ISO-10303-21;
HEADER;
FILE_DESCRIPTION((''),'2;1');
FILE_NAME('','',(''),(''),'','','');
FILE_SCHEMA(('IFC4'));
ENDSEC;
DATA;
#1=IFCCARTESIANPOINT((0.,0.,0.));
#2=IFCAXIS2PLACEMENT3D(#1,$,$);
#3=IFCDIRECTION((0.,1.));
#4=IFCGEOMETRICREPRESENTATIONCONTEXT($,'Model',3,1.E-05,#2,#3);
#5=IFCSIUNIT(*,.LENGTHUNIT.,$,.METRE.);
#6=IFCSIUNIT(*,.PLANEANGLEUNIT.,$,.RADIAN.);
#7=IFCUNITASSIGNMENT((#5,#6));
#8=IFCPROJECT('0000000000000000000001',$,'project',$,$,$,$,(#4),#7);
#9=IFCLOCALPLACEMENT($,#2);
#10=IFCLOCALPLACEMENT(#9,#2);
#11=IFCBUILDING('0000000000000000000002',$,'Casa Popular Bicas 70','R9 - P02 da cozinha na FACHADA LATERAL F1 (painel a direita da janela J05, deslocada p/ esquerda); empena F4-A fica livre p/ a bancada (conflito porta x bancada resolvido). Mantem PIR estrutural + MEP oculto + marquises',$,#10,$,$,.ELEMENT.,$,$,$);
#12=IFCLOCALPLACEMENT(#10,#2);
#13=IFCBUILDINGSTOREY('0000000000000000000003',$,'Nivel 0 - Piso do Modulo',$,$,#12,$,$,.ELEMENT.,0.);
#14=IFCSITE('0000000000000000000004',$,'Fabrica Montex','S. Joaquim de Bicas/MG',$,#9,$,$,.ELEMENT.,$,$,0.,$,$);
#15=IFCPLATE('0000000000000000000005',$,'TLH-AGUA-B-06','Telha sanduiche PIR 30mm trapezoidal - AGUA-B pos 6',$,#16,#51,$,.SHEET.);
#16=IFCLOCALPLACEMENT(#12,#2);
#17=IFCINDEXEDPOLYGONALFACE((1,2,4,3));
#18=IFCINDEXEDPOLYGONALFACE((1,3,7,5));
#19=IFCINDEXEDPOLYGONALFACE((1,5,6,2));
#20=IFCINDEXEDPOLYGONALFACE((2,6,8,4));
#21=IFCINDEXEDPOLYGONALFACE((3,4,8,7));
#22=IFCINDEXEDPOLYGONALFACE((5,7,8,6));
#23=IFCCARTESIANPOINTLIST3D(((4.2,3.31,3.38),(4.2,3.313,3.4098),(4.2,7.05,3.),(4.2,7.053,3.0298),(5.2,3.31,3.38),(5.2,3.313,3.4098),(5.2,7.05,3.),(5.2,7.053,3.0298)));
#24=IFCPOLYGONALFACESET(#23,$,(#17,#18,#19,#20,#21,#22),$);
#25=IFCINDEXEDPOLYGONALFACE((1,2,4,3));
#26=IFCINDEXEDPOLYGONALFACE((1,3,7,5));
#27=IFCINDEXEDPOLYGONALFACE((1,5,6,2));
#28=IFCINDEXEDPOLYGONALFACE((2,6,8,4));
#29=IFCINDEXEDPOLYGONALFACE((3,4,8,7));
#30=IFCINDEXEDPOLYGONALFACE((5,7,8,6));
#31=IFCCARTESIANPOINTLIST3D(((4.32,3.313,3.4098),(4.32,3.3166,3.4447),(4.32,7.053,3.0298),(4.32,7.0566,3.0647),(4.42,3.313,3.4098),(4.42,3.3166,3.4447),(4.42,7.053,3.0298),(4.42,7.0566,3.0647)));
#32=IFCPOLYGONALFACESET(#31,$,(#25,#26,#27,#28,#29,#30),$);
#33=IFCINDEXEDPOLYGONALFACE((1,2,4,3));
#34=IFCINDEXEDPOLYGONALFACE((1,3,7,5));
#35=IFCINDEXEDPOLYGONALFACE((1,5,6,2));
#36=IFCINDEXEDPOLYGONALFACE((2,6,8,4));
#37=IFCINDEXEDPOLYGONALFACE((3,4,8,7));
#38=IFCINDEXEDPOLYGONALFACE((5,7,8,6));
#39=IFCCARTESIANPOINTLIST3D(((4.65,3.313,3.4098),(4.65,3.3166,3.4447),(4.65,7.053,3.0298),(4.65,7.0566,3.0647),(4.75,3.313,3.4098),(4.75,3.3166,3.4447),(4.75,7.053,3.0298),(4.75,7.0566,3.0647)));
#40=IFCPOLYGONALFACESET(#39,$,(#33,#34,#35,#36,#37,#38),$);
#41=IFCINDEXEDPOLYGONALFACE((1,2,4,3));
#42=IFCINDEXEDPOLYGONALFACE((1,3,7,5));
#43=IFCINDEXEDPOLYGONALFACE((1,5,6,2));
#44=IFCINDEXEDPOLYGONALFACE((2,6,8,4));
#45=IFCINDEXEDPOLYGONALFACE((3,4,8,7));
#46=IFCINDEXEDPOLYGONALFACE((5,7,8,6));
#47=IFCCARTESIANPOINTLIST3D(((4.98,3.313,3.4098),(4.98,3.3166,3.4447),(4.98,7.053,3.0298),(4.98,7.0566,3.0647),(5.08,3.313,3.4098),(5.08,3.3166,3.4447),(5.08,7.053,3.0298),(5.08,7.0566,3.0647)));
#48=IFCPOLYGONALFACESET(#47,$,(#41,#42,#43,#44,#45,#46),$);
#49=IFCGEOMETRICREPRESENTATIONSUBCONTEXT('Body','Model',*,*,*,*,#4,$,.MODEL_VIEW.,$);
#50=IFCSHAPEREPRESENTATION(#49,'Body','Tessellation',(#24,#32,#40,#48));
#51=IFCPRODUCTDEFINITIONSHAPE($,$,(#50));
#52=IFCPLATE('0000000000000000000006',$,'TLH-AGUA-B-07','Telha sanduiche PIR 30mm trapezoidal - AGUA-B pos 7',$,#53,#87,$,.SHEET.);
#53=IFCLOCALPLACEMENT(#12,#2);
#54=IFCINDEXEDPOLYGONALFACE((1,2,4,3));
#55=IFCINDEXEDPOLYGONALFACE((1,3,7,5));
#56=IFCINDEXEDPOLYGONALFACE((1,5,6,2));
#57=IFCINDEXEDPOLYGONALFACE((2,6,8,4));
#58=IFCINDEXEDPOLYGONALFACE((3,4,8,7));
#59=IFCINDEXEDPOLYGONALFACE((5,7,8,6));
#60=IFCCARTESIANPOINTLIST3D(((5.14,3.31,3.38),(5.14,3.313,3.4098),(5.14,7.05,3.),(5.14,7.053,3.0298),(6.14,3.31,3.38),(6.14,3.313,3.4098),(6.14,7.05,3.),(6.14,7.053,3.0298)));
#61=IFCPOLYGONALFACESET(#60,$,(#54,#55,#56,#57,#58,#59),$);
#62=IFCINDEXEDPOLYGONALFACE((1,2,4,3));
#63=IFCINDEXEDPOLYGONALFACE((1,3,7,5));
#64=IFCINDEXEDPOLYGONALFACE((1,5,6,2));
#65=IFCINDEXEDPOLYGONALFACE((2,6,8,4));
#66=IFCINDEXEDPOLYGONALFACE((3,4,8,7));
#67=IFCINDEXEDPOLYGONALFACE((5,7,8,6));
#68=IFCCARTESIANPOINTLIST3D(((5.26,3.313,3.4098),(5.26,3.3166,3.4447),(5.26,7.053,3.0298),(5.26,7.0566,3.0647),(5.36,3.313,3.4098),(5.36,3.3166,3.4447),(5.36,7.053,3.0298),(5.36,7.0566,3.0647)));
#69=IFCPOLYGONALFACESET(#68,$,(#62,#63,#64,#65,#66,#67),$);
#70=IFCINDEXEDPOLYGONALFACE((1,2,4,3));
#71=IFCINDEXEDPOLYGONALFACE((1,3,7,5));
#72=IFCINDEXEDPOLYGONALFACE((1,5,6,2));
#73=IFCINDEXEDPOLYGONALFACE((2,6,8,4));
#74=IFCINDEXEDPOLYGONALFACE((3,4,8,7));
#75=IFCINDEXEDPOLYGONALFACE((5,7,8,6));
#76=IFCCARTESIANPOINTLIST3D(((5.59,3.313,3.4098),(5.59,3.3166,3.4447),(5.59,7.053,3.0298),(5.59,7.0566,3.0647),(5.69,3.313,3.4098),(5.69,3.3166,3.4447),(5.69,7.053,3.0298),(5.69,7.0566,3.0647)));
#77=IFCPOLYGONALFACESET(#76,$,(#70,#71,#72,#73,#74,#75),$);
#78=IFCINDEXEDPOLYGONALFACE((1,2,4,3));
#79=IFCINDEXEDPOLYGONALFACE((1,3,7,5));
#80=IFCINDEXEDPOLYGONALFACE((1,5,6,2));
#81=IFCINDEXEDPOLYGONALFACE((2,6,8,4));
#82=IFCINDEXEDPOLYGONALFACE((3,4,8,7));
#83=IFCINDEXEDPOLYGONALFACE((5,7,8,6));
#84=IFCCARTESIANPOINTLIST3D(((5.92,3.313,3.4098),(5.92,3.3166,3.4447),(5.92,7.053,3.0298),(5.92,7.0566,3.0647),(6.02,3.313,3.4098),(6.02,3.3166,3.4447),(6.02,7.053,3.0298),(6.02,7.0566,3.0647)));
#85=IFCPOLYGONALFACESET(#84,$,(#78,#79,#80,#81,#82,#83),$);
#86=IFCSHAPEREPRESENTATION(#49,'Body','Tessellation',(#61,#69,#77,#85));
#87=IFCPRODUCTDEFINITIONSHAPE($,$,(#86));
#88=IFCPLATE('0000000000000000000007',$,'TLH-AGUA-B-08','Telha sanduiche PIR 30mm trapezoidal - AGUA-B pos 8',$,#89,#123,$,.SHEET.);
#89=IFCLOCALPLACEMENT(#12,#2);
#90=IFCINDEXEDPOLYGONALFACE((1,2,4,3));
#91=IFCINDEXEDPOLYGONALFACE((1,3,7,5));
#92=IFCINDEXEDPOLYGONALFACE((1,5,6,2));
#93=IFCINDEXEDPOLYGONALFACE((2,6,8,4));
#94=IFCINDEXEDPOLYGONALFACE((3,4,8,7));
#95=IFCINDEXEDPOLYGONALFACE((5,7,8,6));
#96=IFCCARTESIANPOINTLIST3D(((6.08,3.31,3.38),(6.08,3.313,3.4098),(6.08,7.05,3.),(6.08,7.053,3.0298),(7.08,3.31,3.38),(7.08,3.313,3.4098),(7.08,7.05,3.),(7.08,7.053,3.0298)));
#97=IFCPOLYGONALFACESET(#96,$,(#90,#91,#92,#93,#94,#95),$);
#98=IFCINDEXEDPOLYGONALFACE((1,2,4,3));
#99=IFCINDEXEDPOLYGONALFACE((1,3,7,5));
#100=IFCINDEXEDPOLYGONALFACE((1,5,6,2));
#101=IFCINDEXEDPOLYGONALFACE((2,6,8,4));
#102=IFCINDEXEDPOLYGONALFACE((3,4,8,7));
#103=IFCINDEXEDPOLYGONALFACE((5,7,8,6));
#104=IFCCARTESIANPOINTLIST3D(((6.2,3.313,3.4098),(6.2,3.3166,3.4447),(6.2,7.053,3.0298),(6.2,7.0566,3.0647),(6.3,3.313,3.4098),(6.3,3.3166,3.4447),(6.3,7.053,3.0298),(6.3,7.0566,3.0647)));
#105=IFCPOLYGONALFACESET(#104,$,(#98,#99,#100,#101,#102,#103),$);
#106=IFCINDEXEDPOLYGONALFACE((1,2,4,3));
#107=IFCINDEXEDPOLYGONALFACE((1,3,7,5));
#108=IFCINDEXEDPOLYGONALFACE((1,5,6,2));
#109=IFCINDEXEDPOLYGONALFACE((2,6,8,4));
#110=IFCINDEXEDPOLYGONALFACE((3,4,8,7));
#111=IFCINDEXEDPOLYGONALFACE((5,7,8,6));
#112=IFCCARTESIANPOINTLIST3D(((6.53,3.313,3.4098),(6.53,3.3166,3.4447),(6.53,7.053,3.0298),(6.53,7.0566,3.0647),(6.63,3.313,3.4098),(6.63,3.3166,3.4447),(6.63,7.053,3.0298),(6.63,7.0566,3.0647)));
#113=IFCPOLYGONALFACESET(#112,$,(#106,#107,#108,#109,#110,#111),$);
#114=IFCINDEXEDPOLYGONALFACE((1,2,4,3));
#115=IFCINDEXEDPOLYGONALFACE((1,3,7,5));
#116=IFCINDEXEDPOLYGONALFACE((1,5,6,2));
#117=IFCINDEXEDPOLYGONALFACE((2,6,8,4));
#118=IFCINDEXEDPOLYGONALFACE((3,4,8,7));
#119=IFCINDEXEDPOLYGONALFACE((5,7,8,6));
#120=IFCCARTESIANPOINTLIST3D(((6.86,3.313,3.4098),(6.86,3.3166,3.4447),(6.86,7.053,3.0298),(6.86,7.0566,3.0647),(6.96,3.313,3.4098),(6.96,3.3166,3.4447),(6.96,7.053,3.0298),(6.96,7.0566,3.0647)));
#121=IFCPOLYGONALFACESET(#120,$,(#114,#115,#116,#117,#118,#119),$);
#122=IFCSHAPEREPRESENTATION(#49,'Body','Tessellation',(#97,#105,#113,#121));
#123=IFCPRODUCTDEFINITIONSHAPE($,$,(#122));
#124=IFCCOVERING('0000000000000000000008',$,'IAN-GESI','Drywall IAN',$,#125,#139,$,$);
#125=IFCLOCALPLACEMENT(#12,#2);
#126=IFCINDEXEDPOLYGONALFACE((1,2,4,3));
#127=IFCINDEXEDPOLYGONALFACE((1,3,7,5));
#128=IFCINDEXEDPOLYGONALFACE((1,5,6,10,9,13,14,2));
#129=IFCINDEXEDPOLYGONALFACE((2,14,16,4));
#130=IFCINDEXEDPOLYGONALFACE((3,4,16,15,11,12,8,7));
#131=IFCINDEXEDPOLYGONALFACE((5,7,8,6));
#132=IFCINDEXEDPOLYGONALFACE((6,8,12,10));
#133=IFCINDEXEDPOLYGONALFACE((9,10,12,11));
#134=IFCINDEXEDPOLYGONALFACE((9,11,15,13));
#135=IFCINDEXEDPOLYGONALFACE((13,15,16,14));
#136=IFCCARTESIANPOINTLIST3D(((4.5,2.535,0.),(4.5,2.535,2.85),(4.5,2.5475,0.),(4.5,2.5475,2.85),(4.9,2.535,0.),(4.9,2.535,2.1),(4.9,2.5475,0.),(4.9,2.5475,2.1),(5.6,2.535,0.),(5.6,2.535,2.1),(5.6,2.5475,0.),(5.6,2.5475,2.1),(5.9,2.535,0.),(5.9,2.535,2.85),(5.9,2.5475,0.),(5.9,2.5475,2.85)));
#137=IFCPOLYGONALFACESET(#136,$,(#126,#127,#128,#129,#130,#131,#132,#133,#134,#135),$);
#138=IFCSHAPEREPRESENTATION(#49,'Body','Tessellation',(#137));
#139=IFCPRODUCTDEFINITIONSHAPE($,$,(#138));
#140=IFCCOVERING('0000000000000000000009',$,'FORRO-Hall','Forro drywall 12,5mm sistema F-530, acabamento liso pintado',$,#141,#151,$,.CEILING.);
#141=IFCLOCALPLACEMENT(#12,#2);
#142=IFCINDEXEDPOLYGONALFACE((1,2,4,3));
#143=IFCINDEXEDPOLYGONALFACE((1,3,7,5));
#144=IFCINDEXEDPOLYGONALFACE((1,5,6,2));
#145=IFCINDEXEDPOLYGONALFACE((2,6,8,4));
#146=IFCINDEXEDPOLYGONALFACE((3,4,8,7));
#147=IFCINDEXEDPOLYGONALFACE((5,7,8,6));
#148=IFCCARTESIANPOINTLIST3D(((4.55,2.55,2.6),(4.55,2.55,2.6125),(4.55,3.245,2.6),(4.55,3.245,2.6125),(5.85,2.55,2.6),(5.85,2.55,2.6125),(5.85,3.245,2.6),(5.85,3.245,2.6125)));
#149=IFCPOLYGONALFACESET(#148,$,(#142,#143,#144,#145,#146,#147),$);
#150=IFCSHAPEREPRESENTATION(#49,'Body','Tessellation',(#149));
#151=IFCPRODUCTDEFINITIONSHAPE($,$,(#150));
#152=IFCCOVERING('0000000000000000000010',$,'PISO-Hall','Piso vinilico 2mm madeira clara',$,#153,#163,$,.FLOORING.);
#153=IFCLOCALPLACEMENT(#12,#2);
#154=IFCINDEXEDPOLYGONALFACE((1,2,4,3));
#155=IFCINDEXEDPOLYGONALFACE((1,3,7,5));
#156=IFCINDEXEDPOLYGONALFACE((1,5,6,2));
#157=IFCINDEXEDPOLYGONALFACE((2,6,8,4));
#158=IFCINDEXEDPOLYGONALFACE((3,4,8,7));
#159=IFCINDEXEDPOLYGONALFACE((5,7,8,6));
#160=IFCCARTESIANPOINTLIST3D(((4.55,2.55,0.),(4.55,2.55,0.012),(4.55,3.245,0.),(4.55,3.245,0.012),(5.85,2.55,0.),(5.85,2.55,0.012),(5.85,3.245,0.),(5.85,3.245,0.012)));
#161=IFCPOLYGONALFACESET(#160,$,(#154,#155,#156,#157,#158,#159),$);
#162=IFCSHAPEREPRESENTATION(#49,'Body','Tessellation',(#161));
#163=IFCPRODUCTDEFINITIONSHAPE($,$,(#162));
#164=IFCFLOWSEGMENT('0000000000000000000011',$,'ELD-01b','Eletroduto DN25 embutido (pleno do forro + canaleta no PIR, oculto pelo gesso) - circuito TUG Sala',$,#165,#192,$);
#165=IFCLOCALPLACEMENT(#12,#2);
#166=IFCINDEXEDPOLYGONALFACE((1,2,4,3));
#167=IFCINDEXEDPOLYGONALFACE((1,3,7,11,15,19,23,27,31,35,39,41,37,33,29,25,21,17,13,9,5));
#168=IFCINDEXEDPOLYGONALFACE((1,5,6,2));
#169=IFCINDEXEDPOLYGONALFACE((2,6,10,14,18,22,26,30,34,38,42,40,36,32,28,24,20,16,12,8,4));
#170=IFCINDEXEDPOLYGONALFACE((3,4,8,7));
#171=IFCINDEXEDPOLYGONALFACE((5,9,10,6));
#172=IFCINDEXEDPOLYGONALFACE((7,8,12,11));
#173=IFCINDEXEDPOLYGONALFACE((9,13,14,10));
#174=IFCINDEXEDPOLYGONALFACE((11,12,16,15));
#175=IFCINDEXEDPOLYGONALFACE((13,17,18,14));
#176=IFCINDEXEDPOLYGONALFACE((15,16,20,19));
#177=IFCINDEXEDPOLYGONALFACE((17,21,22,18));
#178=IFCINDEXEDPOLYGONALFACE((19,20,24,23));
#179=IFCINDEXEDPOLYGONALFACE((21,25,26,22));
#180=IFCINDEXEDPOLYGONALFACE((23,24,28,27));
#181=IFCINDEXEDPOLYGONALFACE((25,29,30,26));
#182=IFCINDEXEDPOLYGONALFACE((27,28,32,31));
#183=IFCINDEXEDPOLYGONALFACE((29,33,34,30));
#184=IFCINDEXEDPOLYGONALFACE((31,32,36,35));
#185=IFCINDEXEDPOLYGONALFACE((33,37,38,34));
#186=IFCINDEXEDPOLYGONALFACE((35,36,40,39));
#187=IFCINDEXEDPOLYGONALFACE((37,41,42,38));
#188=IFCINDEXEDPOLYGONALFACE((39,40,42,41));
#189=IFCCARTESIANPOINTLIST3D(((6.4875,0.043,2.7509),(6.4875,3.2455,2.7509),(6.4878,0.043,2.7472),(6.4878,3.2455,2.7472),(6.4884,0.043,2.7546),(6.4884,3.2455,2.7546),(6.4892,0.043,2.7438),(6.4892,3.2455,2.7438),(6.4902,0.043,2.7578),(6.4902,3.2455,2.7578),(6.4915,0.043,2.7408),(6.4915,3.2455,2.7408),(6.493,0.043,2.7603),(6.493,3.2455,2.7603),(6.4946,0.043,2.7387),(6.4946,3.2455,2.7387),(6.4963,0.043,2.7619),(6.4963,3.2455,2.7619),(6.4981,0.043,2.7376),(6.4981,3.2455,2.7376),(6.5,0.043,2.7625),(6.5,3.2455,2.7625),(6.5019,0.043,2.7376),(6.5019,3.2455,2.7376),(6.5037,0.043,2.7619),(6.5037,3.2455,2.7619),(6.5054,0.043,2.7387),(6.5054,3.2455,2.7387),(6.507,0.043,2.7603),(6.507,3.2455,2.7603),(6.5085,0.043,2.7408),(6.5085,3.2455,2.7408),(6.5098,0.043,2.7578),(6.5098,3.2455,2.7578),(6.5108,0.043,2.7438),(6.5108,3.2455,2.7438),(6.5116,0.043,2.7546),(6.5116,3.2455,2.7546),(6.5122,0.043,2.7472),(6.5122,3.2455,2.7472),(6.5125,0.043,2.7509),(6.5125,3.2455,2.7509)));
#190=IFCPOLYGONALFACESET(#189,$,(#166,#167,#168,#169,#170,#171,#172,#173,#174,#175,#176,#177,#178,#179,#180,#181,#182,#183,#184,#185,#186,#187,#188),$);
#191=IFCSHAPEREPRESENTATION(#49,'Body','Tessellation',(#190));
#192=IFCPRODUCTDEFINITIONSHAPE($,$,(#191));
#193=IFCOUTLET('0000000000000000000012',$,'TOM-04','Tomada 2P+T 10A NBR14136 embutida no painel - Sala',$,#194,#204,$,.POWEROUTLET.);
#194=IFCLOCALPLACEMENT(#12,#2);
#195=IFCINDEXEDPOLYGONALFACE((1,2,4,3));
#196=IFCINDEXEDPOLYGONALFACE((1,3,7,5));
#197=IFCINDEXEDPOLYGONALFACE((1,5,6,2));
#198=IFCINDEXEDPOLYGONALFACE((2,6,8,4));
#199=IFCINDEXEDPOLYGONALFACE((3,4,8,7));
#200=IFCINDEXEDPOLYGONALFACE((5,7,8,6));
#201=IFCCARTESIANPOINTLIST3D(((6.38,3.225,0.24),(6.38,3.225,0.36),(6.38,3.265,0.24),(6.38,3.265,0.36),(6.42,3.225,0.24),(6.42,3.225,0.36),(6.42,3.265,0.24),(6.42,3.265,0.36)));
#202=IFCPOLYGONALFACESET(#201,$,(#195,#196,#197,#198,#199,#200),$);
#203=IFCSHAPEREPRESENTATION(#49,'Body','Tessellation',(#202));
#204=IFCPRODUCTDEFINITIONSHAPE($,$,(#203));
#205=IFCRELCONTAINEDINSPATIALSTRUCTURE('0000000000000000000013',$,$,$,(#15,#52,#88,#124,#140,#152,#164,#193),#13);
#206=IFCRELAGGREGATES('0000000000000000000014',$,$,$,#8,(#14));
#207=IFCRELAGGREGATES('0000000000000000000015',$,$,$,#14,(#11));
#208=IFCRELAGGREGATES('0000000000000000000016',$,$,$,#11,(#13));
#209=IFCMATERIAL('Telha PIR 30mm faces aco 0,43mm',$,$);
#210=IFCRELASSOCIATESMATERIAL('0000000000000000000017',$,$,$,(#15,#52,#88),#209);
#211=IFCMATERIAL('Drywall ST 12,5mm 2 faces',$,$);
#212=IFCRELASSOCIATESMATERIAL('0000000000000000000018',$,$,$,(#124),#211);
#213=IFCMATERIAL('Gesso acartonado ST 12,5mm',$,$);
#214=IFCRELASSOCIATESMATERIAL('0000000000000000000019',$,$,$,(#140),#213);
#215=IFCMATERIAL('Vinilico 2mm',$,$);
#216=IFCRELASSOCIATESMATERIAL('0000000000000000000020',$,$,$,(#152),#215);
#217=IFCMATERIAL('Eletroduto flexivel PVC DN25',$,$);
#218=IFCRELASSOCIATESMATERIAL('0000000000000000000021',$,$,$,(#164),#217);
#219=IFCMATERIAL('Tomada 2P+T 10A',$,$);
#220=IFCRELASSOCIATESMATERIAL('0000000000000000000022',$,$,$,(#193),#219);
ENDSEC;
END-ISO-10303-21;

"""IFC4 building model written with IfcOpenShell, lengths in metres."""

from ifc_helpers import new_model, si_unit, direction, frame, frame_2d, origin, origin_2d, place, context, subcontext, project, spatial, rectangle, circle, extrude, material, element, save


model = new_model("IFC4")

# Units and contexts
model_context = context("Model", 3, precision=1e-05, world=origin(), true_north=direction((0.0, 1.0)))
body_context = subcontext(model_context, "Body", "Model", "MODEL_VIEW")
ifc_project = project(units=[si_unit("LENGTHUNIT", "METRE"), si_unit("PLANEANGLEUNIT", "RADIAN")], contexts=[model_context])

# Site, building, storey
site_placement = place(None, origin())
site = spatial("IfcSite", under=ifc_project, at=site_placement, Name="Fabrica Montex", Description="S. Joaquim de Bicas/MG", CompositionType="ELEMENT", RefElevation=0.0)
building_placement = place(site_placement, origin())
building = spatial("IfcBuilding", under=site, at=building_placement, Name="Casa Popular Bicas 70", Description="R9 - P02 da cozinha na FACHADA LATERAL F1 (painel a direita da janela J05, deslocada p/ esquerda); empena F4-A fica livre p/ a bancada (conflito porta x bancada resolvido). Mantem PIR estrutural + MEP oculto + marquises", CompositionType="ELEMENT")
storey_placement = place(building_placement, origin())
storey = spatial("IfcBuildingStorey", under=building, at=storey_placement, Name="Nivel 0 - Piso do Modulo", CompositionType="ELEMENT", Elevation=0.0)

# Plates
ifc_material_1 = material(Name="Telha PIR 30mm faces aco 0,43mm")
for number, where, z_axis, x_axis, name, description in (
    (1, (4.2, 3.31, 3.38), (0.0, 0.101084, 0.994878), (1.0, 0.0, 0.0), "TLH-AGUA-B-06", "Telha sanduiche PIR 30mm trapezoidal - AGUA-B pos 6"),
    (2, (5.14, 3.31, 3.38), (0.0, 0.101084, 0.994878), (1.0, 0.0, 0.0), "TLH-AGUA-B-07", "Telha sanduiche PIR 30mm trapezoidal - AGUA-B pos 7"),
    (3, (6.08, 3.31, 3.38), (0.0, 0.101084, 0.994878), (1.0, 0.0, 0.0), "TLH-AGUA-B-08", "Telha sanduiche PIR 30mm trapezoidal - AGUA-B pos 8"),
):
    element("IfcPlate", number, at=place(storey_placement, frame(where, z_axis=z_axis, x_axis=x_axis)), inside=storey, material=ifc_material_1, Name=name, Description=description, PredefinedType="SHEET", context=body_context, shape_type="SweptSolid", body=[
        extrude(rectangle(XDim=1.0, YDim=3.7593, at=frame_2d((0.5, 1.8796))), origin(), (0.0, 0.0, 1.0), 0.03),
        extrude(rectangle(XDim=0.1, YDim=3.7593, at=frame_2d((0.17, 1.8796))), frame((0.0, 0.0, 0.03)), (0.0, 0.0, 1.0), 0.035),
        extrude(rectangle(XDim=0.1, YDim=3.7593, at=frame_2d((0.5, 1.8796))), frame((0.0, 0.0, 0.03)), (0.0, 0.0, 1.0), 0.035),
        extrude(rectangle(XDim=0.1, YDim=3.7593, at=frame_2d((0.83, 1.8796))), frame((0.0, 0.0, 0.03)), (0.0, 0.0, 1.0), 0.035),
    ])

# Covering, opening
ifc_material_2 = material(Name="Drywall ST 12,5mm 2 faces")
covering_1_placement = place(storey_placement, frame((4.5, 2.5412, 0.0), x_axis=(1.0, 0.0, 0.0)))
covering_1 = element("IfcCovering", 4, at=covering_1_placement, inside=storey, material=ifc_material_2, Name="IAN-GESI", Description="Drywall IAN", context=body_context, shape_type="SweptSolid", body=[
    extrude(rectangle(XDim=1.4, YDim=0.0125, at=frame_2d((0.7, 0.0))), origin(), (0.0, 0.0, 1.0), 2.85),
])
opening_1_placement = place(storey_placement, frame((5.25, 2.5412, 0.0)))
element("IfcOpeningElement", 5, at=opening_1_placement, cuts=covering_1, PredefinedType="OPENING", context=body_context, shape_type="SweptSolid", body=[
    extrude(rectangle(XDim=0.7, YDim=0.0425, at=origin_2d()), origin(), (0.0, 0.0, 1.0), 2.1),
])

# Coverings
ifc_material_3 = material(Name="Gesso acartonado ST 12,5mm")
covering_2_placement = place(storey_placement, frame((4.55, 2.55, 2.6)))
element("IfcCovering", 6, at=covering_2_placement, inside=storey, material=ifc_material_3, Name="FORRO-Hall", Description="Forro drywall 12,5mm sistema F-530, acabamento liso pintado", PredefinedType="CEILING", context=body_context, shape_type="SweptSolid", body=[
    extrude(rectangle(XDim=1.3, YDim=0.695, at=frame_2d((0.65, 0.3475))), origin(), (0.0, 0.0, 1.0), 0.0125),
])
ifc_material_4 = material(Name="Vinilico 2mm")
covering_3_placement = place(storey_placement, frame((4.55, 2.55, 0.0)))
element("IfcCovering", 7, at=covering_3_placement, inside=storey, material=ifc_material_4, Name="PISO-Hall", Description="Piso vinilico 2mm madeira clara", PredefinedType="FLOORING", context=body_context, shape_type="SweptSolid", body=[
    extrude(rectangle(XDim=1.3, YDim=0.695, at=frame_2d((0.65, 0.3475))), origin(), (0.0, 0.0, 1.0), 0.012),
])

# Flow segment
ifc_material_5 = material(Name="Eletroduto flexivel PVC DN25")
flow_segment_1_placement = place(storey_placement, frame((6.5, 3.2455, 2.75), z_axis=(0.0, -1.0, 0.0), x_axis=(0.0, 0.0, 1.0)))
element("IfcFlowSegment", 8, at=flow_segment_1_placement, inside=storey, material=ifc_material_5, Name="ELD-01b", Description="Eletroduto DN25 embutido (pleno do forro + canaleta no PIR, oculto pelo gesso) - circuito TUG Sala", context=body_context, shape_type="SweptSolid", body=[
    extrude(circle(Radius=0.0125, at=origin_2d()), origin(), (0.0, 0.0, 1.0), 3.2025),
])

# Outlet
ifc_material_6 = material(Name="Tomada 2P+T 10A")
outlet_placement = place(storey_placement, frame((6.38, 3.225, 0.24)))
element("IfcOutlet", 9, at=outlet_placement, inside=storey, material=ifc_material_6, Name="TOM-04", Description="Tomada 2P+T 10A NBR14136 embutida no painel - Sala", PredefinedType="POWEROUTLET", context=body_context, shape_type="SweptSolid", body=[
    extrude(rectangle(XDim=0.04, YDim=0.04, at=frame_2d((0.02, 0.02))), origin(), (0.0, 0.0, 1.0), 0.12),
])

save(model, "model.ifc")
